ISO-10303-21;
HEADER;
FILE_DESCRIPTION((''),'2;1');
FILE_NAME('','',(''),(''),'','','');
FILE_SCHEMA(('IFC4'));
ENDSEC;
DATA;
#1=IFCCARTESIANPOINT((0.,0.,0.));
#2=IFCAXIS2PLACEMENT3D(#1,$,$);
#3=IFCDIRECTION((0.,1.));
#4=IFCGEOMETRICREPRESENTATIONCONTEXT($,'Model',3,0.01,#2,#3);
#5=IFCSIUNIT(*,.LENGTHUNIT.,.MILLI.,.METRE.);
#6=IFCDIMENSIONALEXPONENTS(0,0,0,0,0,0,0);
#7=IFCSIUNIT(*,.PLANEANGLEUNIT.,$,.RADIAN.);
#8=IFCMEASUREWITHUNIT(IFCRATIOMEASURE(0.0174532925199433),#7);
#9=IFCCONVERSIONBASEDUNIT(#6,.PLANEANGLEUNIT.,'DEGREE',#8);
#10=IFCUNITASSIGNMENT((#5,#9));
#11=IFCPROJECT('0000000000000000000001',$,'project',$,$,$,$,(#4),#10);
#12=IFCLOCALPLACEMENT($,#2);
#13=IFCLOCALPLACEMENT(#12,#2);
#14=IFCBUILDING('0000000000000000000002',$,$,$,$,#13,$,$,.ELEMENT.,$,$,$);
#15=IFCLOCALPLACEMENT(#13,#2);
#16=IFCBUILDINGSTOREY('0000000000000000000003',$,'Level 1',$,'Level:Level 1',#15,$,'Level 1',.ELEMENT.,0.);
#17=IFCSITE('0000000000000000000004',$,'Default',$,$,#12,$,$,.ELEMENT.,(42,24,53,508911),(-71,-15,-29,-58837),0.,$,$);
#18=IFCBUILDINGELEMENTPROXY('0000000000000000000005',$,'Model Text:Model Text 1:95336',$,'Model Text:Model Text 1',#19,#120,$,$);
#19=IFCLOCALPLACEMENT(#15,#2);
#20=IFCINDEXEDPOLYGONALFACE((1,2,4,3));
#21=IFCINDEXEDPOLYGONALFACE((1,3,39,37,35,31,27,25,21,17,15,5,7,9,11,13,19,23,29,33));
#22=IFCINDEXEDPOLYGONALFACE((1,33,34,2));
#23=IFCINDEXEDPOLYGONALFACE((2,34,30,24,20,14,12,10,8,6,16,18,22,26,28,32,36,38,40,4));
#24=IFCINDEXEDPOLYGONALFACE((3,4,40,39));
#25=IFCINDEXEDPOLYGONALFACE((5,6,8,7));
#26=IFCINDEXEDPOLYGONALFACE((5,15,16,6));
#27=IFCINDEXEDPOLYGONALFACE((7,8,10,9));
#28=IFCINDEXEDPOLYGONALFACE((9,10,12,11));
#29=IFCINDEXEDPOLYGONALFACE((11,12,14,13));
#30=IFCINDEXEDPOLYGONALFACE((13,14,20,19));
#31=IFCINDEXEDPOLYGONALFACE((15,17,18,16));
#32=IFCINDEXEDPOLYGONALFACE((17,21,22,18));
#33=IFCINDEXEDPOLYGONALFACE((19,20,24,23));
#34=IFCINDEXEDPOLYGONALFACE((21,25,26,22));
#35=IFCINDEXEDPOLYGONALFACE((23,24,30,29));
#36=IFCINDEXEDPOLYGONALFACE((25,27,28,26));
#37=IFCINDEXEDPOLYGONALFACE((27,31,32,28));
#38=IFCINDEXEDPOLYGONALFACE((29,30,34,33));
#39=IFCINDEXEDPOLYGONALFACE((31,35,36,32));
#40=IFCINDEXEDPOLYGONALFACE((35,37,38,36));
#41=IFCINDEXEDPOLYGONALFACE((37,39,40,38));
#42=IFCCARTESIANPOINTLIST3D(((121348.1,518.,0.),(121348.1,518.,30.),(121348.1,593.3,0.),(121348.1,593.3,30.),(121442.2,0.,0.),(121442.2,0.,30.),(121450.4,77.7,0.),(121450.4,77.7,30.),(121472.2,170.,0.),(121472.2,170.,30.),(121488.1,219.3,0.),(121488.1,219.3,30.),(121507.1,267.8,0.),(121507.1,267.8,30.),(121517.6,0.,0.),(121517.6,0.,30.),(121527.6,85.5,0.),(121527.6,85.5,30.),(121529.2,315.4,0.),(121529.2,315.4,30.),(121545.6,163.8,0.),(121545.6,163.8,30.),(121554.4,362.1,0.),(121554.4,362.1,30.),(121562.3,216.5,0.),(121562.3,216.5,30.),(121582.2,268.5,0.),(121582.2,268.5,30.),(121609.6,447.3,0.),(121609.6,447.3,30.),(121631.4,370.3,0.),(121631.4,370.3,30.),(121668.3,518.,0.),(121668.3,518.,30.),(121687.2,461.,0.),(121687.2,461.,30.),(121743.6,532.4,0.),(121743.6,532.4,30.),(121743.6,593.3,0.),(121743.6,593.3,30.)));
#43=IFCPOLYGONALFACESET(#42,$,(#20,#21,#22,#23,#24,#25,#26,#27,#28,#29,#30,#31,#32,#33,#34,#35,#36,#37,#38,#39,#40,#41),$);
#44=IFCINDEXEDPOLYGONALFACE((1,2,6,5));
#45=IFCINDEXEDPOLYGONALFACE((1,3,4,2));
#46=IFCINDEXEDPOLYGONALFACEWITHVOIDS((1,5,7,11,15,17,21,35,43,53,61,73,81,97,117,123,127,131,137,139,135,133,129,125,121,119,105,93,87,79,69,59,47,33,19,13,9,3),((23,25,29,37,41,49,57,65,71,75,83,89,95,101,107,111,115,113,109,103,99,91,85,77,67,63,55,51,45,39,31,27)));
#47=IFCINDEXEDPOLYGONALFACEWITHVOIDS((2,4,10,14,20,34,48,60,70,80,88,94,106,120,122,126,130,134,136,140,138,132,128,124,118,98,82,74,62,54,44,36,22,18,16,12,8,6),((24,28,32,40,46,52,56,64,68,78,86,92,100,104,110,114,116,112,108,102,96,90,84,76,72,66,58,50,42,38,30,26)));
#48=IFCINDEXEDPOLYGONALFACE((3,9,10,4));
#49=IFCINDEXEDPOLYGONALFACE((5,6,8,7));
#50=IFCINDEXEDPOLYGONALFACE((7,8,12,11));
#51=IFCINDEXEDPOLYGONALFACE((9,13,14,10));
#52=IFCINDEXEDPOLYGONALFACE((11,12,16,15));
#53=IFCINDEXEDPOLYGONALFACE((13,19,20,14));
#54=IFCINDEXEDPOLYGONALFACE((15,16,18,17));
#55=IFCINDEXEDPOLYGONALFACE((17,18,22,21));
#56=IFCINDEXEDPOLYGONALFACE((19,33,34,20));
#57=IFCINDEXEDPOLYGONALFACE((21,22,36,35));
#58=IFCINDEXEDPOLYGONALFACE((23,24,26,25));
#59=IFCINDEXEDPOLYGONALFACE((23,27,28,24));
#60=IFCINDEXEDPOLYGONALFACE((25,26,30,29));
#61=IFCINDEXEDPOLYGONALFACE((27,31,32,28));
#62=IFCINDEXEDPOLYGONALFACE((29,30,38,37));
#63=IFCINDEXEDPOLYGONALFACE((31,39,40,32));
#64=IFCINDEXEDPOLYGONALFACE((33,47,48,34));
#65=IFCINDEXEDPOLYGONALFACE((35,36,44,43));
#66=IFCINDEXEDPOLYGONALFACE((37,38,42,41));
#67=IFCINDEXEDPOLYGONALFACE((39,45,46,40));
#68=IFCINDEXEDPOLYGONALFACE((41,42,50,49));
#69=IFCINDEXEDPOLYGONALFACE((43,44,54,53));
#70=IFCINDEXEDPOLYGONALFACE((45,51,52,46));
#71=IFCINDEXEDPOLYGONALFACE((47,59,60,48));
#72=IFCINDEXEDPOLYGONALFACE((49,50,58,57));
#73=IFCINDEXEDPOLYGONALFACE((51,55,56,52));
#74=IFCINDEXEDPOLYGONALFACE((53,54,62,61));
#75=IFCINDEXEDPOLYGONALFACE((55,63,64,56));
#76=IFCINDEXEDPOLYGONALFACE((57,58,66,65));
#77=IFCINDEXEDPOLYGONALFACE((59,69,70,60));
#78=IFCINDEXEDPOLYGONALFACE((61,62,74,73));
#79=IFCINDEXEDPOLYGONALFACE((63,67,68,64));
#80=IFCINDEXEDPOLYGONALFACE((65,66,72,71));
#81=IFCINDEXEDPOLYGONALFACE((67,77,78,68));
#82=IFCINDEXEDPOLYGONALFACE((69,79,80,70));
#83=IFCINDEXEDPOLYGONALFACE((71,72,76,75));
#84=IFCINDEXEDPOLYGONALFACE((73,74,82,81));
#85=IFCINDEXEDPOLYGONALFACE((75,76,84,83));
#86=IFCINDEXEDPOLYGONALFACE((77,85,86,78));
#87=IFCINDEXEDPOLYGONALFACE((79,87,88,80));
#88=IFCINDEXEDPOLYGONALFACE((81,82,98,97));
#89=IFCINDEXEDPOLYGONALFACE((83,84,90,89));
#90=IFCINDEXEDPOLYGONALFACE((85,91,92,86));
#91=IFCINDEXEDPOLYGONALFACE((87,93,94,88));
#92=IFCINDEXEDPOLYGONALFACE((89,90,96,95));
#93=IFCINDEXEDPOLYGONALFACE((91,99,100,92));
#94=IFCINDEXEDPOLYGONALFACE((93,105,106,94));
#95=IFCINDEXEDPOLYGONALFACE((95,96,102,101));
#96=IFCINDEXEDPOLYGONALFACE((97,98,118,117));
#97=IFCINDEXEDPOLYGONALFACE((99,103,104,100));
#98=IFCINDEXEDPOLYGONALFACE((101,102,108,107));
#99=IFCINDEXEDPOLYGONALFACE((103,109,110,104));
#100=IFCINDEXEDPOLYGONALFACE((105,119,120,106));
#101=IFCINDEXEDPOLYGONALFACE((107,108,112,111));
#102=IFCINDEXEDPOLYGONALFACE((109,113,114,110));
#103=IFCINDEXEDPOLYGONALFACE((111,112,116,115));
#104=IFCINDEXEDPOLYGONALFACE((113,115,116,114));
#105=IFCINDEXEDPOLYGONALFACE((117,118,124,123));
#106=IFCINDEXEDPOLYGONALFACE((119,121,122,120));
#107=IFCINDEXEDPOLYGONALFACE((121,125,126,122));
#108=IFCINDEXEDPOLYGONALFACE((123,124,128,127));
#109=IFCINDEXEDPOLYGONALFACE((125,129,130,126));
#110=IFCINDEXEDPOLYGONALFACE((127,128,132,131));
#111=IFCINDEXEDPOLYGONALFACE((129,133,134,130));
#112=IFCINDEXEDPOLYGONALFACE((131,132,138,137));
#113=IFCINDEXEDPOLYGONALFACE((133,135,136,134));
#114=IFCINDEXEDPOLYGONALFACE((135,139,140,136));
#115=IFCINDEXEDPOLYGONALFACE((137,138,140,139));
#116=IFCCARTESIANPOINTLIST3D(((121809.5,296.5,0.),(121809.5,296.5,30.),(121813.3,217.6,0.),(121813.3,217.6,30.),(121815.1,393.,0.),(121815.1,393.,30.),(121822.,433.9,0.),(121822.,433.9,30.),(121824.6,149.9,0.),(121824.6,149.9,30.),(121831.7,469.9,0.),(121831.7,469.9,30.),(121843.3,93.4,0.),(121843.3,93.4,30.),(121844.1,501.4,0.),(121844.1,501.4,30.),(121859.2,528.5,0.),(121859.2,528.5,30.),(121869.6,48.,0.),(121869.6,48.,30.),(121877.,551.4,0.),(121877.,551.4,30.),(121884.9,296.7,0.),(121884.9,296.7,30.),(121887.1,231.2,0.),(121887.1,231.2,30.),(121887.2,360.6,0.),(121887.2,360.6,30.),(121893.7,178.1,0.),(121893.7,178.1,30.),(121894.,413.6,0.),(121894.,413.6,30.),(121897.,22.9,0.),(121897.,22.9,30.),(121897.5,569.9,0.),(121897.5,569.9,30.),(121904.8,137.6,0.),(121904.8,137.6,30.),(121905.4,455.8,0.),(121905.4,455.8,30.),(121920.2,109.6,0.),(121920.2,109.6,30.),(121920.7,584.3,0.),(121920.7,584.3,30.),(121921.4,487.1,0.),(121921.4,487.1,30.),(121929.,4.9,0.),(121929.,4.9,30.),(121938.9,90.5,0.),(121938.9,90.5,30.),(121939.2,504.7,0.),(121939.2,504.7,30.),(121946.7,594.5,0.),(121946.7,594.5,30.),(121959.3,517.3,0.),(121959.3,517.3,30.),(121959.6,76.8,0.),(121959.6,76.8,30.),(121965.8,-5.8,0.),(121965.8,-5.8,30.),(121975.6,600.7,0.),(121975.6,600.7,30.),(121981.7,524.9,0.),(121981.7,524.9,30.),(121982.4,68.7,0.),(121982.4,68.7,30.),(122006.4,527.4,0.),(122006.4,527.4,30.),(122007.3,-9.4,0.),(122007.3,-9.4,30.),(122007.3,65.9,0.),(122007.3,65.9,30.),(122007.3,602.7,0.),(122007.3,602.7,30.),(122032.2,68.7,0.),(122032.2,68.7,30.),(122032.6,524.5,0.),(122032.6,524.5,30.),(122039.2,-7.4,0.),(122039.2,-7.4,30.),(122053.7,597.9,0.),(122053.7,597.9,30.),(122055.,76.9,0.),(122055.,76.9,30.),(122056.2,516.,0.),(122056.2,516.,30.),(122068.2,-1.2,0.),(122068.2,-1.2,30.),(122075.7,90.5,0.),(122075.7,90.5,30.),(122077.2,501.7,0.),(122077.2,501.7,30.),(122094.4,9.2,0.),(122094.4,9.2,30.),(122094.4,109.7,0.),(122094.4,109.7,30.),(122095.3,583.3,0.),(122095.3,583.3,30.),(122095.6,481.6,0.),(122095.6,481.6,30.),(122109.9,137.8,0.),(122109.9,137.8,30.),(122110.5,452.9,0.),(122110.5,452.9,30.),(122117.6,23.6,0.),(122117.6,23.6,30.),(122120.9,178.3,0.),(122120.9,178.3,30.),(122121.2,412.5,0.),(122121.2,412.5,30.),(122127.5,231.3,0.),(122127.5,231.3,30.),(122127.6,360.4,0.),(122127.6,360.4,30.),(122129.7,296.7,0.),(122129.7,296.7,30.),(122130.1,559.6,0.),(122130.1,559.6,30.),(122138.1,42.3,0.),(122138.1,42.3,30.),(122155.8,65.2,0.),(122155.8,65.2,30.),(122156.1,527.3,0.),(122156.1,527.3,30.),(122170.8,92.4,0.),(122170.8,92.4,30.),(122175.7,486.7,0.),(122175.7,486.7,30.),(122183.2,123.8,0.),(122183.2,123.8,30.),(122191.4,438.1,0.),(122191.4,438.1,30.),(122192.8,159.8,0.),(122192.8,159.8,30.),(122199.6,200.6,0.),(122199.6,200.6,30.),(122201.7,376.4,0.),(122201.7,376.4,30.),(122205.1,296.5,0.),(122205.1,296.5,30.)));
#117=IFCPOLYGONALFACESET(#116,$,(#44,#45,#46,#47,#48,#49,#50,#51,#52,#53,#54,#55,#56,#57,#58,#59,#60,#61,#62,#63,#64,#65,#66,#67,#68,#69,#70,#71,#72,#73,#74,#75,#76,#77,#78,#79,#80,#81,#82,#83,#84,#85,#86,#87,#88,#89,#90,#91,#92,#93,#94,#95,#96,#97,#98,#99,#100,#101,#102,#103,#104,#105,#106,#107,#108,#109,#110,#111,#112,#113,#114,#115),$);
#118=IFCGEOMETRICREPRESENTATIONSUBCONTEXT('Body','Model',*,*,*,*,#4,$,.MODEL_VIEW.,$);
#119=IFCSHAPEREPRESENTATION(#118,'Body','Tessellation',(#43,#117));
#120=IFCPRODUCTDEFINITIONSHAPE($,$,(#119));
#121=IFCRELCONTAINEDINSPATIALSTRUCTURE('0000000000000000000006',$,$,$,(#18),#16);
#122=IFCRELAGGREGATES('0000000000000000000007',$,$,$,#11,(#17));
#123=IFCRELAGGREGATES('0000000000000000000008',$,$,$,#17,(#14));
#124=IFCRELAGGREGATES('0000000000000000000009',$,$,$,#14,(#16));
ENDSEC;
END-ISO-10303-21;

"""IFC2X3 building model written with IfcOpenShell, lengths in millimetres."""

from ifc_helpers import new_model, entity, si_unit, converted_unit, direction, frame, origin, place, context, subcontext, project, spatial, polyline, outline, extrude, element, save


model = new_model("IFC2X3")

# Units and contexts
model_context = context("Model", 3, precision=0.01, world=origin(), true_north=direction((0.0, 1.0)))
body_context = subcontext(model_context, "Body", "Model", "MODEL_VIEW")
ifc_project = project(units=[si_unit("LENGTHUNIT", "METRE", prefix="MILLI"), converted_unit("PLANEANGLEUNIT", "DEGREE", entity("IfcRatioMeasure", 0.0174532925199433), si_unit("PLANEANGLEUNIT", "RADIAN"), dimensions=[0, 0, 0, 0, 0, 0, 0])], contexts=[model_context])

# Site, building, storey
site_placement = place(None, origin())
site = spatial("IfcSite", under=ifc_project, at=site_placement, Name="Default", CompositionType="ELEMENT", RefLatitude=(42, 24, 53, 508911), RefLongitude=(-71, -15, -29, -58837), RefElevation=0.0)
building_placement = place(site_placement, origin())
building = spatial("IfcBuilding", under=site, at=building_placement, CompositionType="ELEMENT")
storey_placement = place(building_placement, origin())
storey = spatial("IfcBuildingStorey", under=building, at=storey_placement, Name="Level 1", ObjectType="Level:Level 1", LongName="Level 1", CompositionType="ELEMENT", Elevation=0.0)

# Building element proxy
proxy_1_placement = place(storey_placement, origin())
element("IfcBuildingElementProxy", 1, at=proxy_1_placement, inside=storey, Name="Model Text:Model Text 1:95336", ObjectType="Model Text:Model Text 1", context=body_context, shape_type="SweptSolid", body=[
    extrude(outline(polyline([(-199.9, -209.0), (-199.9, -284.3), (195.7, -284.3), (195.7, -223.4), (139.3, -152.0), (83.5, -61.3), (34.2, 40.5), (14.4, 92.5), (-2.4, 145.2), (-20.3, 223.5), (-30.3, 309.0), (-105.7, 309.0), (-97.5, 231.3), (-75.7, 139.0), (-59.9, 89.7), (-40.9, 41.2), (-18.8, -6.4), (6.4, -53.1), (61.7, -138.3), (120.3, -209.0), (-199.9, -209.0)])), frame((121547.9, 309.0, 0.0), z_axis=(0.0, 0.0, -1.0), x_axis=(1.0, 0.0, 0.0)), (0.0, 0.0, -1.0), 30.0),
    extrude(outline(polyline([(-10.6, -198.7), (68.3, -198.7), (136.5, -190.7), (193.9, -174.7), (240.5, -150.6), (266.9, -124.4), (286.3, -93.2), (298.8, -57.0), (304.3, -15.7), (303.8, 16.2), (299.0, 45.5), (289.9, 72.1), (276.6, 96.0), (258.9, 117.3), (236.9, 136.2), (210.4, 152.5), (179.6, 166.3), (144.1, 177.6), (103.7, 186.3), (8.2, 196.4), (-71.8, 196.7), (-134.0, 189.4), (-183.3, 176.1), (-224.7, 158.4), (-258.2, 133.9), (-283.5, 100.3), (-300.1, 59.5), (-307.1, 13.4), (-306.6, -18.4), (-301.8, -47.5), (-292.8, -74.0), (-279.6, -97.9), (-262.0, -119.2), (-240.0, -138.1), (-213.6, -154.5), (-182.8, -168.4), (-147.3, -179.8), (-106.7, -188.6), (-10.6, -198.7)]), holes=[polyline([(-7.2, -123.5), (-71.0, -118.2), (-123.6, -108.8), (-165.2, -95.4), (-195.7, -78.0), (-212.4, -59.4), (-224.1, -38.7), (-230.6, -15.9), (-231.9, 8.9), (-227.8, 35.0), (-218.1, 58.1), (-202.8, 78.4), (-182.0, 95.8), (-152.6, 109.4), (-111.7, 118.1), (-59.4, 122.0), (4.4, 121.1), (69.6, 115.8), (122.2, 106.7), (162.2, 93.7), (189.5, 77.0), (207.7, 57.4), (220.4, 36.0), (227.5, 12.8), (229.1, -12.1), (225.2, -36.8), (215.9, -59.2), (201.3, -79.3), (181.4, -97.1), (152.6, -111.2), (111.6, -120.3), (58.3, -124.4), (-7.2, -123.5)])]), frame((122008.6, 295.3, 0.0), z_axis=(0.0, 0.0, 1.0), x_axis=(0.047515, -0.998871, 0.0)), (0.0, 0.0, 1.0), 30.0),
])

save(model, "model.ifc")
